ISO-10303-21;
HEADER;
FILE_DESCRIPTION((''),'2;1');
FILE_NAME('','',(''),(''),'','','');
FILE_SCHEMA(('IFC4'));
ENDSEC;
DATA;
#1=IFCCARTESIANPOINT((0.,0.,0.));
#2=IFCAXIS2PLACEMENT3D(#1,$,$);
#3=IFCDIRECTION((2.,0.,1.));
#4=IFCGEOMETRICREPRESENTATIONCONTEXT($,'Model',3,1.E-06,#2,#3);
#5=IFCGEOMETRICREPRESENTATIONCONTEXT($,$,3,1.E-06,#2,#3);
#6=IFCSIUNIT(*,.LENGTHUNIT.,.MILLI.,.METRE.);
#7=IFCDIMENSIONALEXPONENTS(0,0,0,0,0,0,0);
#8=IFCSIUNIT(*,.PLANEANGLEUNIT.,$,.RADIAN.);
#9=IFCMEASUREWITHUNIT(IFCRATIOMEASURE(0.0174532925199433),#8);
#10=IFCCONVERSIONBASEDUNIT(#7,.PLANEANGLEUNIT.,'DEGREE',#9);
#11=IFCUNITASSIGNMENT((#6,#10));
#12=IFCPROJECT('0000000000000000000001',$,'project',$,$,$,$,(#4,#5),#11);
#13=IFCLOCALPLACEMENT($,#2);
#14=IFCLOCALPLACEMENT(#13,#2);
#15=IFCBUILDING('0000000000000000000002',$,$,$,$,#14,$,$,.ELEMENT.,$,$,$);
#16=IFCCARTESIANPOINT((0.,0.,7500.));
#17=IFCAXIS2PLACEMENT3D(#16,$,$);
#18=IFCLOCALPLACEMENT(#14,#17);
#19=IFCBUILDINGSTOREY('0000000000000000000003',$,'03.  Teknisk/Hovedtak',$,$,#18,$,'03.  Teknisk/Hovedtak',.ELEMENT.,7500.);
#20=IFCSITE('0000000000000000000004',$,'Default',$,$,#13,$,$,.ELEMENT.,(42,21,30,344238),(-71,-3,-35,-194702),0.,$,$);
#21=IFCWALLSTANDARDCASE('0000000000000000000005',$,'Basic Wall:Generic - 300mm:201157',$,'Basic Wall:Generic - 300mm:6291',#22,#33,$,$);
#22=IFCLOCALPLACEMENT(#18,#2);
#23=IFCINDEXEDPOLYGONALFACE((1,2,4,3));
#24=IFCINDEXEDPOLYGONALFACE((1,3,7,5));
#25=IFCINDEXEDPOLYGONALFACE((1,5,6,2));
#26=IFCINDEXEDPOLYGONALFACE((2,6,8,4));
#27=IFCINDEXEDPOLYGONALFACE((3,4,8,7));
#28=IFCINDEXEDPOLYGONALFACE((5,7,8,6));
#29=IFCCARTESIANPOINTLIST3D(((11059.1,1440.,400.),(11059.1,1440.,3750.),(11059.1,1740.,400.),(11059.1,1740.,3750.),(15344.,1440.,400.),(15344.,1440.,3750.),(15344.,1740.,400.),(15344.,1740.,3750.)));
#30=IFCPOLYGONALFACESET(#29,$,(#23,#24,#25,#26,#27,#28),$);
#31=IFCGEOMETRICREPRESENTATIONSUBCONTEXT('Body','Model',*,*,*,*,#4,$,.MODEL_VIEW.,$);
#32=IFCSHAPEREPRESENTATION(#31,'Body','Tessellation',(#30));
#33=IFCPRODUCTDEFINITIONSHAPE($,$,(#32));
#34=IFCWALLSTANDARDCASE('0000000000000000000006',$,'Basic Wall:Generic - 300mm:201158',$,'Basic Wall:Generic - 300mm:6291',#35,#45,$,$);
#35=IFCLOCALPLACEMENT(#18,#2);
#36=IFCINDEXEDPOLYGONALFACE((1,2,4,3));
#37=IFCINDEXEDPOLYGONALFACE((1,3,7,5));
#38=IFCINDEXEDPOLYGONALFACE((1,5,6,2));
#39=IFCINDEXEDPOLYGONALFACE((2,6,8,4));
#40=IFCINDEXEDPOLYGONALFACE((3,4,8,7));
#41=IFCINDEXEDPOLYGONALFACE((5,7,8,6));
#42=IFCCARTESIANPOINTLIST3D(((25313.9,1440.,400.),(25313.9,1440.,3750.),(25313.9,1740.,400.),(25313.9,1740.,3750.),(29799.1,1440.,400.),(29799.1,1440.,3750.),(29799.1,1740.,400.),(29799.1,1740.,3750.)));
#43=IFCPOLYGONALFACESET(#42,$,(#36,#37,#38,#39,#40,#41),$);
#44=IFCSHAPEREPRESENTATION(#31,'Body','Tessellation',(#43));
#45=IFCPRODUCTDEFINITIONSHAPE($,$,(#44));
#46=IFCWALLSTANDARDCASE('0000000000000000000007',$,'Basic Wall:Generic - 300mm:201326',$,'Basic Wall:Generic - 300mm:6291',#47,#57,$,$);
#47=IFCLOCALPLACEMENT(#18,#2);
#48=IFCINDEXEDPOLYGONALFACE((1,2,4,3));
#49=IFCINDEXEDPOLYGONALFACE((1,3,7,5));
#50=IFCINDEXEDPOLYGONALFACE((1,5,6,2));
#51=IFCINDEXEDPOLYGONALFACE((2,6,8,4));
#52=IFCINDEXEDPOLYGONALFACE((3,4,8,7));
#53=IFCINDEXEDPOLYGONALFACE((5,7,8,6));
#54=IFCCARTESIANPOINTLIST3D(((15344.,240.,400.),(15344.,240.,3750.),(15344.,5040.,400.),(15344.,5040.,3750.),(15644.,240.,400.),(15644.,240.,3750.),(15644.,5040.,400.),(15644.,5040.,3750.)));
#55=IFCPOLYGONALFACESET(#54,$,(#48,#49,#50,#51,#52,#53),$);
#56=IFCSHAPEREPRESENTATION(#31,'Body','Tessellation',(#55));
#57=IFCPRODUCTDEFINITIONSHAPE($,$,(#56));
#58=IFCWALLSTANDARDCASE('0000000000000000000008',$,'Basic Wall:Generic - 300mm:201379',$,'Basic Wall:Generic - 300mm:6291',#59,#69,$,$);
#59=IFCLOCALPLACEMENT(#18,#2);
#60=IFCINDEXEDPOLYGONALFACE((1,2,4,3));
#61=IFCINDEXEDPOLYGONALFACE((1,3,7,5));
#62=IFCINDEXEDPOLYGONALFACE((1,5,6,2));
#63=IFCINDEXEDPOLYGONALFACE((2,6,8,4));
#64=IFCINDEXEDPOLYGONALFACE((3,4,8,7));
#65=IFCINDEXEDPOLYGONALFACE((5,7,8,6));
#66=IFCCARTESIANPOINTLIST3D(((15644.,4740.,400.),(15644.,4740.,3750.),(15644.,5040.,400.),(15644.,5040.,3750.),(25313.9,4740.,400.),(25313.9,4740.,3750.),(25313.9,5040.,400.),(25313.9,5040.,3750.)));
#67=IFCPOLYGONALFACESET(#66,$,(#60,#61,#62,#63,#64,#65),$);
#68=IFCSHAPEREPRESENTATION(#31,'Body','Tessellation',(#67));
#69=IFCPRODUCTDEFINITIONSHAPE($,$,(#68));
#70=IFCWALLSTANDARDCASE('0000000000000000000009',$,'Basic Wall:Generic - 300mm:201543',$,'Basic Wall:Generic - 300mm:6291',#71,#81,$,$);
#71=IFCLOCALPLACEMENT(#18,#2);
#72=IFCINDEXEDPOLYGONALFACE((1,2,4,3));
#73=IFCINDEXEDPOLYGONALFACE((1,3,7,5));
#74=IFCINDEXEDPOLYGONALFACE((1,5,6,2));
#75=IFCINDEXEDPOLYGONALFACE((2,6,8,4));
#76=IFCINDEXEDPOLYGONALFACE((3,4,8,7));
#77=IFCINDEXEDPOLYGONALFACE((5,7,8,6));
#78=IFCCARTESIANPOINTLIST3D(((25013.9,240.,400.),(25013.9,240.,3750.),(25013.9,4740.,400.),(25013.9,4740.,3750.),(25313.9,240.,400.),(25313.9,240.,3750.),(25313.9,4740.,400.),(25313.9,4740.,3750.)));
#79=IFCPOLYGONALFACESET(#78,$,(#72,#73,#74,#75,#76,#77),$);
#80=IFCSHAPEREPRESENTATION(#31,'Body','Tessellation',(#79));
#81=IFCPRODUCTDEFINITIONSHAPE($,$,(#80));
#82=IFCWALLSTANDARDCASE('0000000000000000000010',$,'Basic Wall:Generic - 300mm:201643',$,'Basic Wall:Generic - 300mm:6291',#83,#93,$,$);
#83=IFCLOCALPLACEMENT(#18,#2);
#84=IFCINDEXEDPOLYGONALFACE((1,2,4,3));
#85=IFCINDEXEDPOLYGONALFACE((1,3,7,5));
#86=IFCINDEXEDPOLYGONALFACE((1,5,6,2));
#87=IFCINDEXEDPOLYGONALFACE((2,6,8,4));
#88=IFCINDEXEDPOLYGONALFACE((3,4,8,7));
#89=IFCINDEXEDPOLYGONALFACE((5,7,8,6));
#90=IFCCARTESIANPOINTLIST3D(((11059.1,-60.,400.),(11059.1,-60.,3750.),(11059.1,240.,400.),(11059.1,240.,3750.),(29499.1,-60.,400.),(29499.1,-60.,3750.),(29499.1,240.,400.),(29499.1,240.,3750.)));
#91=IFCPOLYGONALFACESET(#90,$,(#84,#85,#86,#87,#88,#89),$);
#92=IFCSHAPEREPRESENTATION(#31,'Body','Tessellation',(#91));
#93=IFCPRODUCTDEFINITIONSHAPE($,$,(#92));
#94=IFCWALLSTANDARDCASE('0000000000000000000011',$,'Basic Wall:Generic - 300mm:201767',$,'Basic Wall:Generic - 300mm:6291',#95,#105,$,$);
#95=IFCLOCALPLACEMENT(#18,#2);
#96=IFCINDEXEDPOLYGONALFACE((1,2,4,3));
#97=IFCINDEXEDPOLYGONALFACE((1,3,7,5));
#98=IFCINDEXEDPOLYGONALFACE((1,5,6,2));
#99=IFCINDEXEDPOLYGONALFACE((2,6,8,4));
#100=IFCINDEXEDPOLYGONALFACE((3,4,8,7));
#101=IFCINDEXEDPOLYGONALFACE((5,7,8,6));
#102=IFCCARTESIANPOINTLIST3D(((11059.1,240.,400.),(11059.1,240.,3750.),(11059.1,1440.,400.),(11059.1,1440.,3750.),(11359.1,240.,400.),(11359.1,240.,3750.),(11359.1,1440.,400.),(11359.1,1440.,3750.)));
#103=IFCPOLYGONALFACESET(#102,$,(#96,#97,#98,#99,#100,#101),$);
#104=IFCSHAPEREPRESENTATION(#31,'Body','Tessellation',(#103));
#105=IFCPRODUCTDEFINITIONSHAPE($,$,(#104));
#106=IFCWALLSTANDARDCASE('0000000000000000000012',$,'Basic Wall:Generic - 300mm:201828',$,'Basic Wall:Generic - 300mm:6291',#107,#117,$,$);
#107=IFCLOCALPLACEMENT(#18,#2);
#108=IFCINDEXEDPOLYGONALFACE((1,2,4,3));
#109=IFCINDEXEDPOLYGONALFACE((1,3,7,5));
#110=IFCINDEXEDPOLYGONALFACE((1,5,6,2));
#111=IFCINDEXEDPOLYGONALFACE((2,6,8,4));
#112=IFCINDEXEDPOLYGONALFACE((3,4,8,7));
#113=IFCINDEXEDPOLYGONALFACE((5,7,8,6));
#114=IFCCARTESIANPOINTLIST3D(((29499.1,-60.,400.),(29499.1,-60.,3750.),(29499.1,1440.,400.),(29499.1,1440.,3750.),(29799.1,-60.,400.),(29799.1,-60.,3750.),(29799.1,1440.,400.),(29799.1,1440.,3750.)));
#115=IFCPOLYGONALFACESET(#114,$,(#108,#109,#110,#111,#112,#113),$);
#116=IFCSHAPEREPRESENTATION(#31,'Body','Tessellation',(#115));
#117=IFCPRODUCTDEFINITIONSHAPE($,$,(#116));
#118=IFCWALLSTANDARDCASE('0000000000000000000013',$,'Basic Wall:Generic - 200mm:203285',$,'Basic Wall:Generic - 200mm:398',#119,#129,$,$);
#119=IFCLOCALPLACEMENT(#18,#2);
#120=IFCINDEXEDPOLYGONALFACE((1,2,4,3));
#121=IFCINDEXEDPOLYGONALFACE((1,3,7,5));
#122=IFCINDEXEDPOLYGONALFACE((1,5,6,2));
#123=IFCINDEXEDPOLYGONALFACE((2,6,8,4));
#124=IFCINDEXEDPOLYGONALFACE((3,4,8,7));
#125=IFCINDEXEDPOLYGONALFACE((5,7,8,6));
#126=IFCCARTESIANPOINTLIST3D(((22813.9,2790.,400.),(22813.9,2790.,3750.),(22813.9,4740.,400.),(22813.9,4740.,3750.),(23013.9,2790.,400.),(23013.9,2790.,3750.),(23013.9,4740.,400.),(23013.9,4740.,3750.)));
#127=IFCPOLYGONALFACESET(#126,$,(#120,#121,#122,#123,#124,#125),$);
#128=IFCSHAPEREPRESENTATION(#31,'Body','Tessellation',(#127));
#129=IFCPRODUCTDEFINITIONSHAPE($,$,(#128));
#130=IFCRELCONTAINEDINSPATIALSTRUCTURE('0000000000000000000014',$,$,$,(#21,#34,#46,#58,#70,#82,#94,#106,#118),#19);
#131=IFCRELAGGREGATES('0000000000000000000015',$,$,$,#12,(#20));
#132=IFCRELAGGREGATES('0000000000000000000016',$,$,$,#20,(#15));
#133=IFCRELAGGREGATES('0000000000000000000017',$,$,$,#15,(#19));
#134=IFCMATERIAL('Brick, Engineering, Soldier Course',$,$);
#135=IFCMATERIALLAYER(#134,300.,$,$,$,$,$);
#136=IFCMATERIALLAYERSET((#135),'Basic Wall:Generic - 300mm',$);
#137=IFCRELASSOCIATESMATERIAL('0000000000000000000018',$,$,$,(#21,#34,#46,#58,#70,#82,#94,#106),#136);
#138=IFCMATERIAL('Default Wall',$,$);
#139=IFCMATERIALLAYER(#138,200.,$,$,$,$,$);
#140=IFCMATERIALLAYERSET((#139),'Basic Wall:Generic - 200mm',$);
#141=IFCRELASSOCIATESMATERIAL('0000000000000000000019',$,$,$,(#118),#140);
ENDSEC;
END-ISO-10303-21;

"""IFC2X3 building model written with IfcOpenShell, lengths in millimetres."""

from ifc_helpers import new_model, entity, si_unit, converted_unit, direction, frame, frame_2d, origin, place, context, subcontext, project, spatial, rectangle, extrude, material, layer, layer_set, layer_usage, element, save


model = new_model("IFC2X3")

# Units and contexts
model_context = context("Model", 3, precision=1e-06, world=origin(), true_north=direction((2.0, 0.0, 1.0)))
context_of_model = context(None, 3, precision=1e-06, world=origin(), true_north=direction((2.0, 0.0, 1.0)))
body_context = subcontext(model_context, "Body", "Model", "MODEL_VIEW")
ifc_project = project(units=[si_unit("LENGTHUNIT", "METRE", prefix="MILLI"), converted_unit("PLANEANGLEUNIT", "DEGREE", entity("IfcRatioMeasure", 0.0174532925199433), si_unit("PLANEANGLEUNIT", "RADIAN"), dimensions=[0, 0, 0, 0, 0, 0, 0])], contexts=[model_context, context_of_model])

# Site, building, storey
site_placement = place(None, origin())
site = spatial("IfcSite", under=ifc_project, at=site_placement, Name="Default", CompositionType="ELEMENT", RefLatitude=(42, 21, 30, 344238), RefLongitude=(-71, -3, -35, -194702), RefElevation=0.0)
building_placement = place(site_placement, origin())
building = spatial("IfcBuilding", under=site, at=building_placement, CompositionType="ELEMENT")
storey_placement = place(building_placement, frame((0.0, 0.0, 7500.0)))
storey = spatial("IfcBuildingStorey", under=building, at=storey_placement, Name="03.  Teknisk/Hovedtak", LongName="03.  Teknisk/Hovedtak", CompositionType="ELEMENT", Elevation=7500.0)

# Walls
ifc_material_1 = material(Name="Brick, Engineering, Soldier Course")
ifc_layer_1 = layer(ifc_material_1, 300.0)
ifc_layer_set_1 = layer_set([ifc_layer_1], Name="Basic Wall:Generic - 300mm")
ifc_layer_usage_1 = layer_usage(ifc_layer_set_1, "AXIS2", "NEGATIVE", 150.0)
wall_1_placement = place(storey_placement, frame((15344.0, 1590.0, 400.0), z_axis=(0.0, 0.0, 1.0), x_axis=(-1.0, 0.0, 0.0)))
element("IfcWallStandardCase", 1, at=wall_1_placement, inside=storey, material=ifc_layer_usage_1, Name="Basic Wall:Generic - 300mm:201157", ObjectType="Basic Wall:Generic - 300mm:6291", context=body_context, shape_type="SweptSolid", body=[
    extrude(rectangle(XDim=4284.9, YDim=300.0, at=frame_2d((2142.4, 0.0), x_axis=(-1.0, 0.0))), origin(), (0.0, 0.0, 1.0), 3350.0),
])
ifc_layer_usage_2 = layer_usage(ifc_layer_set_1, "AXIS2", "NEGATIVE", 150.0)
wall_2_placement = place(storey_placement, frame((29799.1, 1590.0, 400.0), z_axis=(0.0, 0.0, 1.0), x_axis=(-1.0, 0.0, 0.0)))
element("IfcWallStandardCase", 2, at=wall_2_placement, inside=storey, material=ifc_layer_usage_2, Name="Basic Wall:Generic - 300mm:201158", ObjectType="Basic Wall:Generic - 300mm:6291", context=body_context, shape_type="SweptSolid", body=[
    extrude(rectangle(XDim=4485.2, YDim=300.0, at=frame_2d((2242.6, 0.0), x_axis=(-1.0, 0.0))), origin(), (0.0, 0.0, 1.0), 3350.0),
])
ifc_layer_usage_3 = layer_usage(ifc_layer_set_1, "AXIS2", "NEGATIVE", 150.0)
wall_3_placement = place(storey_placement, frame((15494.0, 240.0, 400.0), z_axis=(0.0, 0.0, 1.0), x_axis=(0.0, 1.0, 0.0)))
element("IfcWallStandardCase", 3, at=wall_3_placement, inside=storey, material=ifc_layer_usage_3, Name="Basic Wall:Generic - 300mm:201326", ObjectType="Basic Wall:Generic - 300mm:6291", context=body_context, shape_type="SweptSolid", body=[
    extrude(rectangle(XDim=4800.0, YDim=300.0, at=frame_2d((2400.0, 0.0), x_axis=(-1.0, 0.0))), origin(), (0.0, 0.0, 1.0), 3350.0),
])
ifc_layer_usage_4 = layer_usage(ifc_layer_set_1, "AXIS2", "NEGATIVE", 150.0)
wall_4_placement = place(storey_placement, frame((15644.0, 4890.0, 400.0)))
element("IfcWallStandardCase", 4, at=wall_4_placement, inside=storey, material=ifc_layer_usage_4, Name="Basic Wall:Generic - 300mm:201379", ObjectType="Basic Wall:Generic - 300mm:6291", context=body_context, shape_type="SweptSolid", body=[
    extrude(rectangle(XDim=9669.9, YDim=300.0, at=frame_2d((4834.9, 0.0), x_axis=(-1.0, 0.0))), origin(), (0.0, 0.0, 1.0), 3350.0),
])
ifc_layer_usage_5 = layer_usage(ifc_layer_set_1, "AXIS2", "NEGATIVE", 150.0)
wall_5_placement = place(storey_placement, frame((25163.9, 4740.0, 400.0), z_axis=(0.0, 0.0, 1.0), x_axis=(0.0, -1.0, 0.0)))
element("IfcWallStandardCase", 5, at=wall_5_placement, inside=storey, material=ifc_layer_usage_5, Name="Basic Wall:Generic - 300mm:201543", ObjectType="Basic Wall:Generic - 300mm:6291", context=body_context, shape_type="SweptSolid", body=[
    extrude(rectangle(XDim=4500.0, YDim=300.0, at=frame_2d((2250.0, 0.0), x_axis=(-1.0, 0.0))), origin(), (0.0, 0.0, 1.0), 3350.0),
])
ifc_layer_usage_6 = layer_usage(ifc_layer_set_1, "AXIS2", "NEGATIVE", 150.0)
wall_6_placement = place(storey_placement, frame((29499.1, 90.0, 400.0), z_axis=(0.0, 0.0, 1.0), x_axis=(-1.0, 0.0, 0.0)))
element("IfcWallStandardCase", 6, at=wall_6_placement, inside=storey, material=ifc_layer_usage_6, Name="Basic Wall:Generic - 300mm:201643", ObjectType="Basic Wall:Generic - 300mm:6291", context=body_context, shape_type="SweptSolid", body=[
    extrude(rectangle(XDim=18440.0, YDim=300.0, at=frame_2d((9220.0, 0.0), x_axis=(-1.0, 0.0))), origin(), (0.0, 0.0, 1.0), 3350.0),
])
ifc_layer_usage_7 = layer_usage(ifc_layer_set_1, "AXIS2", "POSITIVE", -150.0)
wall_7_placement = place(storey_placement, frame((11209.1, 1440.0, 400.0), z_axis=(0.0, 0.0, 1.0), x_axis=(0.0, -1.0, 0.0)))
element("IfcWallStandardCase", 7, at=wall_7_placement, inside=storey, material=ifc_layer_usage_7, Name="Basic Wall:Generic - 300mm:201767", ObjectType="Basic Wall:Generic - 300mm:6291", context=body_context, shape_type="SweptSolid", body=[
    extrude(rectangle(XDim=1200.0, YDim=300.0, at=frame_2d((600.0, 0.0), x_axis=(-1.0, 0.0))), origin(), (0.0, 0.0, 1.0), 3350.0),
])
ifc_layer_usage_8 = layer_usage(ifc_layer_set_1, "AXIS2", "NEGATIVE", 150.0)
wall_8_placement = place(storey_placement, frame((29649.1, 1440.0, 400.0), z_axis=(0.0, 0.0, 1.0), x_axis=(0.0, -1.0, 0.0)))
element("IfcWallStandardCase", 8, at=wall_8_placement, inside=storey, material=ifc_layer_usage_8, Name="Basic Wall:Generic - 300mm:201828", ObjectType="Basic Wall:Generic - 300mm:6291", context=body_context, shape_type="SweptSolid", body=[
    extrude(rectangle(XDim=1500.0, YDim=300.0, at=frame_2d((750.0, 0.0), x_axis=(-1.0, 0.0))), origin(), (0.0, 0.0, 1.0), 3350.0),
])
ifc_material_2 = material(Name="Default Wall")
ifc_layer_2 = layer(ifc_material_2, 200.0)
ifc_layer_set_2 = layer_set([ifc_layer_2], Name="Basic Wall:Generic - 200mm")
ifc_layer_usage_9 = layer_usage(ifc_layer_set_2, "AXIS2", "NEGATIVE", 100.0)
wall_9_placement = place(storey_placement, frame((22913.9, 4740.0, 400.0), z_axis=(0.0, 0.0, 1.0), x_axis=(0.0, -1.0, 0.0)))
element("IfcWallStandardCase", 9, at=wall_9_placement, inside=storey, material=ifc_layer_usage_9, Name="Basic Wall:Generic - 200mm:203285", ObjectType="Basic Wall:Generic - 200mm:398", context=body_context, shape_type="SweptSolid", body=[
    extrude(rectangle(XDim=1950.0, YDim=200.0, at=frame_2d((975.0, 0.0), x_axis=(-1.0, 0.0))), origin(), (0.0, 0.0, 1.0), 3350.0),
])

save(model, "model.ifc")
